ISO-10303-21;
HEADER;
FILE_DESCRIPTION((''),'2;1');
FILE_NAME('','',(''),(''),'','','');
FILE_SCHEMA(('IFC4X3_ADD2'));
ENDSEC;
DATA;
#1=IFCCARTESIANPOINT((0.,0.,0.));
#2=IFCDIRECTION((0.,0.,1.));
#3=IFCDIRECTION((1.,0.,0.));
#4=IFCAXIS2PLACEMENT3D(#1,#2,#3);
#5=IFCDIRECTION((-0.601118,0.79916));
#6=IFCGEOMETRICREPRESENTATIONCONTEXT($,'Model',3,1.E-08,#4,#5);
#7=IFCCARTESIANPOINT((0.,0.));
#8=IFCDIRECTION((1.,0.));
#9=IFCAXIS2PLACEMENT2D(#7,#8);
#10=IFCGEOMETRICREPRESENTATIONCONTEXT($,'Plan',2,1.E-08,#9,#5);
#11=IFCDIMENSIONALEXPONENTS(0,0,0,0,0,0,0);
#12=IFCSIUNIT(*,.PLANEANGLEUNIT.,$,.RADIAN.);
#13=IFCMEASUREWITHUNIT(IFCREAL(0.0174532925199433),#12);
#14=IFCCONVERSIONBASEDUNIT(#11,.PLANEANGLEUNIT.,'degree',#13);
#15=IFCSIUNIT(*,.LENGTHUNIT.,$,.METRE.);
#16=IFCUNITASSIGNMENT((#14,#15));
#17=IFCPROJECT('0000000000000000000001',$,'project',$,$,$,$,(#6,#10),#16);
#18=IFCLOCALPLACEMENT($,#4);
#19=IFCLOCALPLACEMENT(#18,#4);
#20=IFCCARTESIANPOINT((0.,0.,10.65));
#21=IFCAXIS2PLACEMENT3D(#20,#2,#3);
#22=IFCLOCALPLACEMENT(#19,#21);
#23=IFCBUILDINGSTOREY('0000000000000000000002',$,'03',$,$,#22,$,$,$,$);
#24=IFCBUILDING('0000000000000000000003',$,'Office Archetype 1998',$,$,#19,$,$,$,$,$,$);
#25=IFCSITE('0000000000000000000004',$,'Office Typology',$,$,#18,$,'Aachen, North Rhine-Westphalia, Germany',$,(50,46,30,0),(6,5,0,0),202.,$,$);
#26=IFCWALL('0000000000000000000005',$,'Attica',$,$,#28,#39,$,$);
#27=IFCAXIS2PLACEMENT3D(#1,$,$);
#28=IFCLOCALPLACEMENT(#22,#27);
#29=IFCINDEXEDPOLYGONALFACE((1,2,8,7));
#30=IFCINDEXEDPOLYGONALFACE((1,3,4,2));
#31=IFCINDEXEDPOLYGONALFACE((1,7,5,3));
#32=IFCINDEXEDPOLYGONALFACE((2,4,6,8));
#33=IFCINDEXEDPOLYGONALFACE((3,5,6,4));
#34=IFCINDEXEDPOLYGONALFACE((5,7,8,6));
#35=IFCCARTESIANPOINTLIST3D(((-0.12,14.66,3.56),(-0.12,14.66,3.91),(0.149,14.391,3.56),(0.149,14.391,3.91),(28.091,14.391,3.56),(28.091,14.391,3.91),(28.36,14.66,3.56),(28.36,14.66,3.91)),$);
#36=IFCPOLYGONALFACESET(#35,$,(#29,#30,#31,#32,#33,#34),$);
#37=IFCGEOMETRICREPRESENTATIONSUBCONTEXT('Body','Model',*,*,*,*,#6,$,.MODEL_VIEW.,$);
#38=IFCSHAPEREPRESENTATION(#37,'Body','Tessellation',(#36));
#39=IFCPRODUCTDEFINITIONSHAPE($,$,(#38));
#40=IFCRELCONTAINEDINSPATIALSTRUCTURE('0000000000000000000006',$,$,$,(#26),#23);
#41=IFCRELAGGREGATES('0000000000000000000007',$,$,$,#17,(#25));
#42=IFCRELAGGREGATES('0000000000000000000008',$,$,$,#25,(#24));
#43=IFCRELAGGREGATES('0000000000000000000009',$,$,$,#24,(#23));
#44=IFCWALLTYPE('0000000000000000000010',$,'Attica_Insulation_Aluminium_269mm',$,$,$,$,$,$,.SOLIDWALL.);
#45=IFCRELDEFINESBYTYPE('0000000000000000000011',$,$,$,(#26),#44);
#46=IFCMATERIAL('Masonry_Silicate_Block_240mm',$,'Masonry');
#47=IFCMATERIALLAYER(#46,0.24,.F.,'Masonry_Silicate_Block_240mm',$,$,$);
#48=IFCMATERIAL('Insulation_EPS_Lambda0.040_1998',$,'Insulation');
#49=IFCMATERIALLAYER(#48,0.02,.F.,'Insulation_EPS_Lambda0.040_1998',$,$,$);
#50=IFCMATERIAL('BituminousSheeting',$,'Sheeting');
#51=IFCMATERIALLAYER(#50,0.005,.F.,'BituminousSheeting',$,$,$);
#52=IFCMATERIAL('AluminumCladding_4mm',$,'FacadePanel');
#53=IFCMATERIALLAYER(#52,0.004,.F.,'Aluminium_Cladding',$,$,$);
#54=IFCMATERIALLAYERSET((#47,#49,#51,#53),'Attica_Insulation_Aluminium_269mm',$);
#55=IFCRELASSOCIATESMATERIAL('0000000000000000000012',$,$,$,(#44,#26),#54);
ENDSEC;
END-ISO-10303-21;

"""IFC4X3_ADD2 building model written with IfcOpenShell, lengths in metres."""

from ifc_helpers import new_model, entity, si_unit, converted_unit, direction, frame, origin_with_axes, origin_2d_with_axis, place, context, subcontext, project, spatial, line, indexed_curve, outline, extrude, material, layer, layer_set, layer_usage, type_object, element, save


model = new_model("IFC4X3_ADD2")

# Units and contexts
model_context = context("Model", 3, precision=1e-08, world=origin_with_axes(), true_north=direction((-0.601118, 0.79916)))
plan_context = context("Plan", 2, precision=1e-08, world=origin_2d_with_axis(), true_north=direction((-0.601118, 0.79916)))
body_context = subcontext(model_context, "Body", "Model", "MODEL_VIEW")
ifc_project = project(units=[converted_unit("PLANEANGLEUNIT", "degree", entity("IfcReal", 0.0174532925199433), si_unit("PLANEANGLEUNIT", "RADIAN"), dimensions=[0, 0, 0, 0, 0, 0, 0]), si_unit("LENGTHUNIT", "METRE")], contexts=[model_context, plan_context])

# Site, building, storey
site_placement = place(None, origin_with_axes())
site = spatial("IfcSite", under=ifc_project, at=site_placement, Name="Office Typology", LongName="Aachen, North Rhine-Westphalia, Germany", RefLatitude=(50, 46, 30, 0), RefLongitude=(6, 5, 0, 0), RefElevation=202.0)
building_placement = place(site_placement, origin_with_axes())
building = spatial("IfcBuilding", under=site, at=building_placement, Name="Office Archetype 1998")
storey_placement = place(building_placement, frame((0.0, 0.0, 10.65), z_axis=(0.0, 0.0, 1.0), x_axis=(1.0, 0.0, 0.0)))
storey = spatial("IfcBuildingStorey", under=building, at=storey_placement, Name="03")

# Shared definitions
ifc_material_1 = material(Name="Masonry_Silicate_Block_240mm", Category="Masonry")

# Wall
ifc_layer_1 = layer(ifc_material_1, 0.24, ventilated=False, Name="Masonry_Silicate_Block_240mm")
ifc_material_2 = material(Name="Insulation_EPS_Lambda0.040_1998", Category="Insulation")
ifc_layer_2 = layer(ifc_material_2, 0.02, ventilated=False, Name="Insulation_EPS_Lambda0.040_1998")
ifc_material_3 = material(Name="BituminousSheeting", Category="Sheeting")
ifc_layer_3 = layer(ifc_material_3, 0.005, ventilated=False, Name="BituminousSheeting")
ifc_material_4 = material(Name="AluminumCladding_4mm", Category="FacadePanel")
ifc_layer_4 = layer(ifc_material_4, 0.004, ventilated=False, Name="Aluminium_Cladding")
ifc_layer_set_1 = layer_set([ifc_layer_1, ifc_layer_2, ifc_layer_3, ifc_layer_4], Name="Attica_Insulation_Aluminium_269mm")
ifc_layer_usage_1 = layer_usage(ifc_layer_set_1, "AXIS2", "POSITIVE", 0.0)
wall_type_1 = type_object("IfcWallType", Name="Attica_Insulation_Aluminium_269mm", PredefinedType="SOLIDWALL", material=ifc_layer_set_1)
wall_1_placement = place(storey_placement, frame((28.36, 14.66, 3.56), z_axis=(0.0, 0.0, 1.0), x_axis=(-1.0, 0.0, 0.0)))
element("IfcWall", 1, at=wall_1_placement, inside=storey, type_object=wall_type_1, material=ifc_layer_usage_1, Name="Attica", context=body_context, shape_type="SweptSolid", body=[
    extrude(outline(indexed_curve([(0.0, 0.0), (0.269, 0.269), (28.211, 0.269), (28.48, 0.0)], segments=[line(1, 2, 3, 4, 1)])), origin_with_axes(), (0.0, 0.0, 1.0), 0.35),
])

save(model, "model.ifc")
